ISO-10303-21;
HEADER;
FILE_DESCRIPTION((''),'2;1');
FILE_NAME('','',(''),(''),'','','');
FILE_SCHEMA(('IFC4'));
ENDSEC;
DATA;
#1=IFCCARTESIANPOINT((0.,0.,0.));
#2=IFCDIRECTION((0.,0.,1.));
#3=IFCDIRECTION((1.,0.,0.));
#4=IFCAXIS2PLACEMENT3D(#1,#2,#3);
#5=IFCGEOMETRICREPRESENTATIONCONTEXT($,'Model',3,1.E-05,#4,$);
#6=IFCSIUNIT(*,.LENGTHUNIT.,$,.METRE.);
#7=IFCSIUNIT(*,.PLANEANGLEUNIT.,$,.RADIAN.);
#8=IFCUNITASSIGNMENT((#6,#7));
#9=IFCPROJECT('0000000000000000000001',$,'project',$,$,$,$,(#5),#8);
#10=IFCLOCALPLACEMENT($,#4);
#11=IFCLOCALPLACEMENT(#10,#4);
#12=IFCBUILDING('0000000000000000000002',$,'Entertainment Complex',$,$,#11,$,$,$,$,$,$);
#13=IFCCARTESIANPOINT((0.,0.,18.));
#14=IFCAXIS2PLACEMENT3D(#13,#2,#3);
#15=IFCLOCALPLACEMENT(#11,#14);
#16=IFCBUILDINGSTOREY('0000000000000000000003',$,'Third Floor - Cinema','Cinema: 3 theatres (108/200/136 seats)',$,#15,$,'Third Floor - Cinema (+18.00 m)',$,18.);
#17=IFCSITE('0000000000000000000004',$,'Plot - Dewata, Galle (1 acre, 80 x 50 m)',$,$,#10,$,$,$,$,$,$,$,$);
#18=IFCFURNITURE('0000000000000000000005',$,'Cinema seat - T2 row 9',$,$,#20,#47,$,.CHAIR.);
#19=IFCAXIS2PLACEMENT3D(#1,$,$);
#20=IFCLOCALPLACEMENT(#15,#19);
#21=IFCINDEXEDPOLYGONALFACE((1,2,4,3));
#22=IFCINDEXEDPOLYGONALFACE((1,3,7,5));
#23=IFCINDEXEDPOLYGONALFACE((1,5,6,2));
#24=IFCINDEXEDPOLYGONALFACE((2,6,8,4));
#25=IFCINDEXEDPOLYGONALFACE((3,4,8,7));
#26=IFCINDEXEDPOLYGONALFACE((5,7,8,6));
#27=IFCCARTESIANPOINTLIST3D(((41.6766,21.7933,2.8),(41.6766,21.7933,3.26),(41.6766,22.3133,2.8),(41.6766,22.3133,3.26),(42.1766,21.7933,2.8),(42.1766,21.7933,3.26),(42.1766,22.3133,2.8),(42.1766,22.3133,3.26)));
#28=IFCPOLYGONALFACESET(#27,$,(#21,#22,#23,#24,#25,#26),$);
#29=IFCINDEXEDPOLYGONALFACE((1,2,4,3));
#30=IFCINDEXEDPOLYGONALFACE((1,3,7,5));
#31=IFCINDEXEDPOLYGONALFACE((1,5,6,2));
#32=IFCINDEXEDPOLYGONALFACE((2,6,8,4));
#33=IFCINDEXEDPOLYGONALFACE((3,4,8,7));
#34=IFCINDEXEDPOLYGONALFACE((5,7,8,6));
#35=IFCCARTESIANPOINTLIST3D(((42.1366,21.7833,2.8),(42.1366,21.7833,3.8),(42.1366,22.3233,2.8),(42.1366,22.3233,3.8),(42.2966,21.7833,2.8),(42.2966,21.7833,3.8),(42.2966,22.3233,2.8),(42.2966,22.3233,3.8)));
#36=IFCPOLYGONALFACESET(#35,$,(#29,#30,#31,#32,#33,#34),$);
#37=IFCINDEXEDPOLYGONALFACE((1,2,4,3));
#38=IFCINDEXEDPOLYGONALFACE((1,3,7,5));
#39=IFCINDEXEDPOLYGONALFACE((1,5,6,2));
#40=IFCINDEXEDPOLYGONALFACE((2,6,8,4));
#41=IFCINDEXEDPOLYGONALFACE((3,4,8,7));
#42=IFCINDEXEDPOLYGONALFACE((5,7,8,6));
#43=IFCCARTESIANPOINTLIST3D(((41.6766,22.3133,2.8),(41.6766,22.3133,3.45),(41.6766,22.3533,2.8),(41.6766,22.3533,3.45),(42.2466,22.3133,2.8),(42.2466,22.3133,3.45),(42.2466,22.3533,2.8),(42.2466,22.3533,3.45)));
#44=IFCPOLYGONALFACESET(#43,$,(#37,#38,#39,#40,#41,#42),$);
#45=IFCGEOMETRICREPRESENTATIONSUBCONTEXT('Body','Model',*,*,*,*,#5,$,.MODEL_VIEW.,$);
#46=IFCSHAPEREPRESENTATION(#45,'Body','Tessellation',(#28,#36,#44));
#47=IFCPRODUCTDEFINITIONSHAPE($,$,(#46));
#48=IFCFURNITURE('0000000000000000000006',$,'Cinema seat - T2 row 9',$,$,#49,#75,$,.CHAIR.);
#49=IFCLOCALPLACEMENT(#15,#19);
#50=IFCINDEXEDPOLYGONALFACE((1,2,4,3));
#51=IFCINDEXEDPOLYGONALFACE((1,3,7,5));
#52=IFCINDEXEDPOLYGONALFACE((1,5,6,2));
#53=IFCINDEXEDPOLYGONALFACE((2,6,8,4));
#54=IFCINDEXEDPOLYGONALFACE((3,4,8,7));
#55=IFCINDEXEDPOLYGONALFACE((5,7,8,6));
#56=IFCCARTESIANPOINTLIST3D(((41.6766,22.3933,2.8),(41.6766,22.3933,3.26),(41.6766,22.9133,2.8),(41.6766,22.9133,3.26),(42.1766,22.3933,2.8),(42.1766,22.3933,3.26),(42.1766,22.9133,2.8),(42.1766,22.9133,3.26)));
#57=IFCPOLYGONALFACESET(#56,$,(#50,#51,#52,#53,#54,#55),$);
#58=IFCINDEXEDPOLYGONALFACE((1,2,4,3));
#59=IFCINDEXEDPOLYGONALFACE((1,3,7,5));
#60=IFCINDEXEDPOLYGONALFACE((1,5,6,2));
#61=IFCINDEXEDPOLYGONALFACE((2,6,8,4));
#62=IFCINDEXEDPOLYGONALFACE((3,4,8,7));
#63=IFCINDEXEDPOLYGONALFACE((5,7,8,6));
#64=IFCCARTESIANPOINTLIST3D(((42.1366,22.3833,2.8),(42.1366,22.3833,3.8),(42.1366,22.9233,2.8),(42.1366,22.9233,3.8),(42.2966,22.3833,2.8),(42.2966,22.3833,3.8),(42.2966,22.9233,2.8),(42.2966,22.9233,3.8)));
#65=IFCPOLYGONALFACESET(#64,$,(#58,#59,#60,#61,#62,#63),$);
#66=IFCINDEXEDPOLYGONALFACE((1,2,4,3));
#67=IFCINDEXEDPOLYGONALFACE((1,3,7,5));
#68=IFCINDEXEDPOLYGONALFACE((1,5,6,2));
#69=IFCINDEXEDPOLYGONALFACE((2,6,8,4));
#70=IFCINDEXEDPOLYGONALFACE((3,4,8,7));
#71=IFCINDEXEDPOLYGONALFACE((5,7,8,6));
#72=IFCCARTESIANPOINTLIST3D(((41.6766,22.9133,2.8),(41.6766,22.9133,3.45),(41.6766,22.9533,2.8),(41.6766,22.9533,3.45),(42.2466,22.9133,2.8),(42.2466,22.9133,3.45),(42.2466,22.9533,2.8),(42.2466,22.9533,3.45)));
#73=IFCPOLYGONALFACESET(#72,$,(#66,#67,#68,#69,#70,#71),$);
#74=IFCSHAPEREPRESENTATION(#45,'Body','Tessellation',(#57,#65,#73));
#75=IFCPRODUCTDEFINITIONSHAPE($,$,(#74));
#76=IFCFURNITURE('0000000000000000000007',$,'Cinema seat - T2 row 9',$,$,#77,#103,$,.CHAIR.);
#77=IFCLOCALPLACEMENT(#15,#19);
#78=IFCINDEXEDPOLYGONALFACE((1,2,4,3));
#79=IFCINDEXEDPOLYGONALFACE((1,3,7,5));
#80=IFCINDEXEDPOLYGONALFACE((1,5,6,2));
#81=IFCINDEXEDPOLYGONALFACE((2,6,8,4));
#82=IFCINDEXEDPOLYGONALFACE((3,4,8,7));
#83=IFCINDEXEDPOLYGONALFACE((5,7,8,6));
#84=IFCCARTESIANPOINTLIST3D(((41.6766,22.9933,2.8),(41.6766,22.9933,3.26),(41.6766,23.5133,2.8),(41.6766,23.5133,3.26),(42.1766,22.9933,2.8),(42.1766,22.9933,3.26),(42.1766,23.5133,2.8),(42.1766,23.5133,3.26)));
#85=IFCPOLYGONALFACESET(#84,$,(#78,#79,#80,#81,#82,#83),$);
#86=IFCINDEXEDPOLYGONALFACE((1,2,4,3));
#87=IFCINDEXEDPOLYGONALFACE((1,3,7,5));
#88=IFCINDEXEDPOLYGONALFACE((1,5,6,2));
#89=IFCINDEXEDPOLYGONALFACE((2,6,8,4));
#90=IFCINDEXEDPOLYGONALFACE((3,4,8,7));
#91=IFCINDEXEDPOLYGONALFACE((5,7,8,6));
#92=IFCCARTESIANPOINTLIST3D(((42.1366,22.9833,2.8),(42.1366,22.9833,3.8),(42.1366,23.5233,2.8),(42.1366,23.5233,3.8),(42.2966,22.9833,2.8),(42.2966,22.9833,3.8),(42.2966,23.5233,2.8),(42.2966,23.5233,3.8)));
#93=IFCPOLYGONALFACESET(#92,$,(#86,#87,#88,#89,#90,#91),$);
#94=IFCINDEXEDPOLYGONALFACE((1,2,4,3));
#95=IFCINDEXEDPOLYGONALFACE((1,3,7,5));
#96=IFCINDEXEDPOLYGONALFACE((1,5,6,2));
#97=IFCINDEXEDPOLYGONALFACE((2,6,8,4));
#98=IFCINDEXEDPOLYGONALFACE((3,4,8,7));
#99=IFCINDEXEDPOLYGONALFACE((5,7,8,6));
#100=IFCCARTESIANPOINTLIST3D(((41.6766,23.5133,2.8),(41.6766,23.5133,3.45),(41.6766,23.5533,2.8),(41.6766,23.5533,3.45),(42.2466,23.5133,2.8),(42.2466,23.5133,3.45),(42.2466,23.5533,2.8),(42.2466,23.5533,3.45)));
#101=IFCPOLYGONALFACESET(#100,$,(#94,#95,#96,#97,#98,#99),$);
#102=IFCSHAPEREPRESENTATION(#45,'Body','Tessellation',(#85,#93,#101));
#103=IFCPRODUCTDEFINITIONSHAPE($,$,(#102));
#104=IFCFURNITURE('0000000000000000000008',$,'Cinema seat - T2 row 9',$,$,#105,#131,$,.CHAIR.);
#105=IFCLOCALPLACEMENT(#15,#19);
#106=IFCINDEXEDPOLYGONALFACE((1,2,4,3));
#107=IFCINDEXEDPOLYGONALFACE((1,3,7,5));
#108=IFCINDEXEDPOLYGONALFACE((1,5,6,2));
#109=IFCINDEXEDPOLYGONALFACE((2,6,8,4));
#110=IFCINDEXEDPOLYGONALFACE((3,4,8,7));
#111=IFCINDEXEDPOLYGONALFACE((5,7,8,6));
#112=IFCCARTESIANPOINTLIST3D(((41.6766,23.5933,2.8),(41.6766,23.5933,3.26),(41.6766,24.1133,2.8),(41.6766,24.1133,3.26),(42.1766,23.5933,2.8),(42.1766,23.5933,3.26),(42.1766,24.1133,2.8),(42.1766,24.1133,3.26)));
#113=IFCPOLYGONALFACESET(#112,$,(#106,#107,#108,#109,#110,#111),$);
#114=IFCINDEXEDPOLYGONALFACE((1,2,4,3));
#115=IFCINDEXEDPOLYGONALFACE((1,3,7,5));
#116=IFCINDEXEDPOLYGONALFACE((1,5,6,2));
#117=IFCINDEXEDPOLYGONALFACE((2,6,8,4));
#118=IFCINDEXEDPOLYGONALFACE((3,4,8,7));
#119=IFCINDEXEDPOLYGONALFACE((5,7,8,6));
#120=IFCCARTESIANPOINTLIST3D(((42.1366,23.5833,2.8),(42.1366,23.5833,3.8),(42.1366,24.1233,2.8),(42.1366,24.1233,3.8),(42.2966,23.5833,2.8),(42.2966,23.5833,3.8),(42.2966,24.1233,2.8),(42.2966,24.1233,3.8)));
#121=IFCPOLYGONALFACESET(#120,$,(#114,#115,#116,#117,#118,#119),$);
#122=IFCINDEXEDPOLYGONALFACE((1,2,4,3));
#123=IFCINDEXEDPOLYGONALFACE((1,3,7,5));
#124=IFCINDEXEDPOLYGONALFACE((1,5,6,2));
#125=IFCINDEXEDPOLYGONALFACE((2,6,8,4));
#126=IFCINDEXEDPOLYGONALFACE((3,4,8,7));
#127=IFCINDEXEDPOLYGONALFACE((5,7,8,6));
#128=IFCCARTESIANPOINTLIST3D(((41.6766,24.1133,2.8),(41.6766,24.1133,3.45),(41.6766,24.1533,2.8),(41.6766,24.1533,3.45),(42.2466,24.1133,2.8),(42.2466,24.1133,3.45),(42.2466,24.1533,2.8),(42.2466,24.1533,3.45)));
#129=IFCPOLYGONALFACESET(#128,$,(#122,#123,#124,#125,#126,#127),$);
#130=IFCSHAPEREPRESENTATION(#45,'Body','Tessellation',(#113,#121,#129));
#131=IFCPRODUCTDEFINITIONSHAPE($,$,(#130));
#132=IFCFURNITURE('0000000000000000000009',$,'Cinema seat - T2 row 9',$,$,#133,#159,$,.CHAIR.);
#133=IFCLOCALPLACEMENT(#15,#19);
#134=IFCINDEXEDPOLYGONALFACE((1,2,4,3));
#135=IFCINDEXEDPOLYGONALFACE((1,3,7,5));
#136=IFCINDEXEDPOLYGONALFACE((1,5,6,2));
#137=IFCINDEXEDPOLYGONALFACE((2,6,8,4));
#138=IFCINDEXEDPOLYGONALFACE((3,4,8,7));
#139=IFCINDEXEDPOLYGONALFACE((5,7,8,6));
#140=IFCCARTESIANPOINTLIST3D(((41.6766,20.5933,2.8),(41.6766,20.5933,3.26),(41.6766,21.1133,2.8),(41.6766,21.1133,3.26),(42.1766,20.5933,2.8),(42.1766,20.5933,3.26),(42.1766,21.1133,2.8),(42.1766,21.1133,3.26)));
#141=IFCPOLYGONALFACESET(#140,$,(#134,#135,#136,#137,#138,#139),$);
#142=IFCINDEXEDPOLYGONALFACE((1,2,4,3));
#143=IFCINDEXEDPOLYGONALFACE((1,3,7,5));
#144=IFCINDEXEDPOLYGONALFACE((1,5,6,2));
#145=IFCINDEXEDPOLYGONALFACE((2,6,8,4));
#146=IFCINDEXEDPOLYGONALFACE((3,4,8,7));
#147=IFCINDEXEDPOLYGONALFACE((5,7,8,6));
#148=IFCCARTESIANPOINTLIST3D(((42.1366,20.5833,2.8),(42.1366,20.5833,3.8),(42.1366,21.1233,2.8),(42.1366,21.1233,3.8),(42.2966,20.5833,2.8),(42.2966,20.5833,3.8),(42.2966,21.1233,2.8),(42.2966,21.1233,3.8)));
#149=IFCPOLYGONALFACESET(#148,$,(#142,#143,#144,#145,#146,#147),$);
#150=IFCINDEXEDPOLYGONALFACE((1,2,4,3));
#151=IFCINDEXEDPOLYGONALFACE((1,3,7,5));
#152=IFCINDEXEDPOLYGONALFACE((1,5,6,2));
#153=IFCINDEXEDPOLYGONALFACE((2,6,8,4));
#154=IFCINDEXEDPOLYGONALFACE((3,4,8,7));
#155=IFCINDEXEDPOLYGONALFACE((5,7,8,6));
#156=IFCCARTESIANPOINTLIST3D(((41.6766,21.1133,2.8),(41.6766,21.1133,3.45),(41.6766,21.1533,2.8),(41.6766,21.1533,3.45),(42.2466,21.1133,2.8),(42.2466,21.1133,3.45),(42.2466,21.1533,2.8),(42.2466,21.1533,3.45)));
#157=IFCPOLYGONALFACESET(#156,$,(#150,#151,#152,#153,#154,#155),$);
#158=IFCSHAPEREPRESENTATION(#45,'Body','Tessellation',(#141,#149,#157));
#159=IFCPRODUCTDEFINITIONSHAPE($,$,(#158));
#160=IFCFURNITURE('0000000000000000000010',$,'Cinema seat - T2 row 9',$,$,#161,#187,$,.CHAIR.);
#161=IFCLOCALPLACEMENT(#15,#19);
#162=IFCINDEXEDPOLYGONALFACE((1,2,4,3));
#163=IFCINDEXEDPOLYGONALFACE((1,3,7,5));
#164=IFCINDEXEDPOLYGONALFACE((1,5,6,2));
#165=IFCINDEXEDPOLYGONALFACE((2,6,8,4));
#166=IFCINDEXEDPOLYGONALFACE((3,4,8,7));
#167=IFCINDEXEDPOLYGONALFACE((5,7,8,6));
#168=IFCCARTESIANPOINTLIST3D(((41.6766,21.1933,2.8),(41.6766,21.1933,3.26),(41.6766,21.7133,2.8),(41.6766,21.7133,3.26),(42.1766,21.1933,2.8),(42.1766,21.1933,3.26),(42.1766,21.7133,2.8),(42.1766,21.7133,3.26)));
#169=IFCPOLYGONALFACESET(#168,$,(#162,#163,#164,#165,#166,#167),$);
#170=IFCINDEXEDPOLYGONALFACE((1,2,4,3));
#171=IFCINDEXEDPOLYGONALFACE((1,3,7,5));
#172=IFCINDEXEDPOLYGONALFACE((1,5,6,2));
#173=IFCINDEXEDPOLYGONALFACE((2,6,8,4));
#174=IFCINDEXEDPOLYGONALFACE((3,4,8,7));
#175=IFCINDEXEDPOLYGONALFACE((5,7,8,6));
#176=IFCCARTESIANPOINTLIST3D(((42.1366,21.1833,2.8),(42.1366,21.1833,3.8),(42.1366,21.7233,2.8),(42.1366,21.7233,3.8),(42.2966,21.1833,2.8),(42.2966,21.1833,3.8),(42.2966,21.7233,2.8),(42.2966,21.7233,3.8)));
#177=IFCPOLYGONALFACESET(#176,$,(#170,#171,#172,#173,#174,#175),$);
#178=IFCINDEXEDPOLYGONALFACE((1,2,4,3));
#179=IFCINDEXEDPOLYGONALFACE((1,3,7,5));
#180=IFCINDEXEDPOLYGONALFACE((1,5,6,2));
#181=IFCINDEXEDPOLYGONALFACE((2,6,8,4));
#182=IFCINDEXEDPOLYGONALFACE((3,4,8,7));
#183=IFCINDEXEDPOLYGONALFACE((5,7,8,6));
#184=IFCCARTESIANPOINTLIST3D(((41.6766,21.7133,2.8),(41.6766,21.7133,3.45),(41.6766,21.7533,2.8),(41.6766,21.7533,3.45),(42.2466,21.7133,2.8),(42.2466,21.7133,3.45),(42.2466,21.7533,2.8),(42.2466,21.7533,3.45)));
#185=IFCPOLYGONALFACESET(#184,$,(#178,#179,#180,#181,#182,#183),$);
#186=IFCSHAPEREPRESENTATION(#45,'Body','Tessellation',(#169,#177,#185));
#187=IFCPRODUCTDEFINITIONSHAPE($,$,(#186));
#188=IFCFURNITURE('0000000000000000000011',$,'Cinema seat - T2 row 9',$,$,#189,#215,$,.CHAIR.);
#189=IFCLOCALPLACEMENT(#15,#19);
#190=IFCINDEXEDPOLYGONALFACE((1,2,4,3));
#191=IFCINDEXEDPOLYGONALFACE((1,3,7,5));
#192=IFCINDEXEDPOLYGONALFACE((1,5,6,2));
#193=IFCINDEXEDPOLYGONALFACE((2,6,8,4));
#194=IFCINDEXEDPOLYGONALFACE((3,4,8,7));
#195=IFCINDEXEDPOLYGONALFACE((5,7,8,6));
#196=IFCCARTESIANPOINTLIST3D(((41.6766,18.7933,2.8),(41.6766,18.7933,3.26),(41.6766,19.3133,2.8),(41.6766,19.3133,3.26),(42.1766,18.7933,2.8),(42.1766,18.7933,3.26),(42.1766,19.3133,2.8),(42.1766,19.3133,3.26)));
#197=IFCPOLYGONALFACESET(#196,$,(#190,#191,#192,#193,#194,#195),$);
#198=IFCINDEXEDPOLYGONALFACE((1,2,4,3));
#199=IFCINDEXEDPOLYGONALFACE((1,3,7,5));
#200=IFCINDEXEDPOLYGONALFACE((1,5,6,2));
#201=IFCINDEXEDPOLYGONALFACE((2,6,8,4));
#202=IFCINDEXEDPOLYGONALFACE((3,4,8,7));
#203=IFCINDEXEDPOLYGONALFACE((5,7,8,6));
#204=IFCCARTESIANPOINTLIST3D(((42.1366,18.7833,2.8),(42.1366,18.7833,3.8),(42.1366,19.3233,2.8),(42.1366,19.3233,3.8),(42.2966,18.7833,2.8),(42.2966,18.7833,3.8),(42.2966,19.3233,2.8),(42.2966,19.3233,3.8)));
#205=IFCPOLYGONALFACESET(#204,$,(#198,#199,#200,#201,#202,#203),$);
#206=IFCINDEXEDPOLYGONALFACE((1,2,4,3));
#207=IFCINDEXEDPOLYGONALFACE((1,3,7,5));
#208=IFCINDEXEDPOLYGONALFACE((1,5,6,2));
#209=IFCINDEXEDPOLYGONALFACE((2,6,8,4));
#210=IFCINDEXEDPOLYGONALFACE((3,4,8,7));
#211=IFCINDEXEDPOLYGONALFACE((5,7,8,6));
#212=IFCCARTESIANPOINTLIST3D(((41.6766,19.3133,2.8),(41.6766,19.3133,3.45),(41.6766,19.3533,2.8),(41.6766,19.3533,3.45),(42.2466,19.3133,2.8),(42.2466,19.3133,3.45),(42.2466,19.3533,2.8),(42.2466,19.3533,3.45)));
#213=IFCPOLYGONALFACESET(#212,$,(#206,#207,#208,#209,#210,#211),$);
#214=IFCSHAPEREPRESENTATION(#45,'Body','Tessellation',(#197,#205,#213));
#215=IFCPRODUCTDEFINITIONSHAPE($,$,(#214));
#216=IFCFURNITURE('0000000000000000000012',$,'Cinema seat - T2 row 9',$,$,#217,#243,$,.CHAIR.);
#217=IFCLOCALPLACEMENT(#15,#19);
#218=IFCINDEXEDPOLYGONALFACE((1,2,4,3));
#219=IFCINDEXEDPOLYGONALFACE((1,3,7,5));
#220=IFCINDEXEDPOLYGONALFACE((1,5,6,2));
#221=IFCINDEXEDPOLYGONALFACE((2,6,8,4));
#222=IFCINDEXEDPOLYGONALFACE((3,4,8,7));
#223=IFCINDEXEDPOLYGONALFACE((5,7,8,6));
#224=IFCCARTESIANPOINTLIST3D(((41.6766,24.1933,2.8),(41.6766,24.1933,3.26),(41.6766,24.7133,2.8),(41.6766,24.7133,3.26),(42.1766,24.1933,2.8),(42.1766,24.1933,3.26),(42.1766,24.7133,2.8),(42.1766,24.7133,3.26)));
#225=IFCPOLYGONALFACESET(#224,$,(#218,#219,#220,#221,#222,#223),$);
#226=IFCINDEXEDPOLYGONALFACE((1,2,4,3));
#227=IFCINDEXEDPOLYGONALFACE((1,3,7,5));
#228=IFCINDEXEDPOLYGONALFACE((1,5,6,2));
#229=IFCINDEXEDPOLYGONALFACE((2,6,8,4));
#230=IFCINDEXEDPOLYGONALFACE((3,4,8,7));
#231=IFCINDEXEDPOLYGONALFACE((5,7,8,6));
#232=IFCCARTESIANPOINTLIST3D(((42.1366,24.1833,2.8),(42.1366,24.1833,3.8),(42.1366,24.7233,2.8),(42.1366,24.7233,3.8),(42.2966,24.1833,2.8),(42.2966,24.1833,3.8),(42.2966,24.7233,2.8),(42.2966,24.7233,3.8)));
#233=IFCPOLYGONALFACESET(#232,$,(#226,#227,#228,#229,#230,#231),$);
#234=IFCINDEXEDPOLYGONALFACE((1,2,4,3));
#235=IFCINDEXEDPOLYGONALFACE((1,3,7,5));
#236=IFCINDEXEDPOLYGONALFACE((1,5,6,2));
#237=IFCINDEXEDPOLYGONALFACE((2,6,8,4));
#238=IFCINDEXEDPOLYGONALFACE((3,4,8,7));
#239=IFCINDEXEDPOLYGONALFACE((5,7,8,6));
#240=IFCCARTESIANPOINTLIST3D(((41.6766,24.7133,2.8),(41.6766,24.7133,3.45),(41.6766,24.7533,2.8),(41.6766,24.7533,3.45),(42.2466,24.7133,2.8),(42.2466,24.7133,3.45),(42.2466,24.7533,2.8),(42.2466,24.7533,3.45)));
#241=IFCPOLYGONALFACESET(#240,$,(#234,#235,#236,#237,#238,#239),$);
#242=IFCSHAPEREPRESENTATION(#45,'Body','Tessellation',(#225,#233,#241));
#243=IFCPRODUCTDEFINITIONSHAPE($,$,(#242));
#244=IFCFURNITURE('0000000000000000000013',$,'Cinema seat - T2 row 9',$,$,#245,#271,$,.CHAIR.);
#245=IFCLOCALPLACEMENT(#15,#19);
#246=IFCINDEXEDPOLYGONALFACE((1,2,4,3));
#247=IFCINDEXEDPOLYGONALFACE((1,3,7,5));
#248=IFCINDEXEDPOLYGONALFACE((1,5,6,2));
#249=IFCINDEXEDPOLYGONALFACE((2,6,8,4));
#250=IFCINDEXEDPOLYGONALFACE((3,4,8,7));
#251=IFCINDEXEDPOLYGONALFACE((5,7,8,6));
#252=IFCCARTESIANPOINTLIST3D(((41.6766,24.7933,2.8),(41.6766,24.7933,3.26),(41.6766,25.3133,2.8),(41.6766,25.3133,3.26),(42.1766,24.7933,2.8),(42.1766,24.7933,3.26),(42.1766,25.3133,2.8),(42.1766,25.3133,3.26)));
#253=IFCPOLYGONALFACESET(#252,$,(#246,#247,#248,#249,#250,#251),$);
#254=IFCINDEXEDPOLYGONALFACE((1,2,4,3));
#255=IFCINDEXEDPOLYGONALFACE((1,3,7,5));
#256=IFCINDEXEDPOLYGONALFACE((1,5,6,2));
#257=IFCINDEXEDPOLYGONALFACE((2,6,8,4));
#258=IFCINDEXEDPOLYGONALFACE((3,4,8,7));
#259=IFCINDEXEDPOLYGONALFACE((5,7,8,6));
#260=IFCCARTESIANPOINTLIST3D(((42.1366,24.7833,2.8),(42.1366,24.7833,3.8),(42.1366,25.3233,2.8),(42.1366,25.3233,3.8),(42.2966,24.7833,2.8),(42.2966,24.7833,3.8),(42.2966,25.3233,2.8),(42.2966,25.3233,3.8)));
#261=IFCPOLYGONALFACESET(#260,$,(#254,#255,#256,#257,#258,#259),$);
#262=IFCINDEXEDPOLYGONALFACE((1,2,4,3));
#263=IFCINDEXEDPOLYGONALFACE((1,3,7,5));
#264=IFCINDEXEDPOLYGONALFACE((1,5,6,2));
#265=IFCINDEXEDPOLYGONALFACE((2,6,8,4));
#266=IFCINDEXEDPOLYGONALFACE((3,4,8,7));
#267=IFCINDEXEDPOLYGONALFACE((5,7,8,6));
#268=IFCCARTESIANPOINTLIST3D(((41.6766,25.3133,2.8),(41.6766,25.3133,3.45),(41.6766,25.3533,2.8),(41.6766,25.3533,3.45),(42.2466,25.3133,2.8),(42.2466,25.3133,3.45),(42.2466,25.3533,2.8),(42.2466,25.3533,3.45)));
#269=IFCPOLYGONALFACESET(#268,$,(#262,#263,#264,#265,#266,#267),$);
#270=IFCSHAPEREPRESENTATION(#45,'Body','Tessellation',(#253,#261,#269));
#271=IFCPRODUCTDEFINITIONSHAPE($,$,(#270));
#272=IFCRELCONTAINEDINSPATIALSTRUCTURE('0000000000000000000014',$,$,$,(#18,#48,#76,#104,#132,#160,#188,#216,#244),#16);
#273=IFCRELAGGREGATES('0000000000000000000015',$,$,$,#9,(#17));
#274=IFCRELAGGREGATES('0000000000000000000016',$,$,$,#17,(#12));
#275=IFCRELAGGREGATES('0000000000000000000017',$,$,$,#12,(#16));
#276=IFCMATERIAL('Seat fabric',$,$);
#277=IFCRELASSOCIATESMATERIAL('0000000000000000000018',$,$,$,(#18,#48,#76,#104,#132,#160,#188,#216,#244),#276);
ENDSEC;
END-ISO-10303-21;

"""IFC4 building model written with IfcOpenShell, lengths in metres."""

from ifc_helpers import new_model, si_unit, frame, origin_with_axes, place, context, subcontext, project, spatial, polyline, outline, extrude, material, element, save


model = new_model("IFC4")

# Units and contexts
model_context = context("Model", 3, precision=1e-05, world=origin_with_axes())
body_context = subcontext(model_context, "Body", "Model", "MODEL_VIEW")
ifc_project = project(units=[si_unit("LENGTHUNIT", "METRE"), si_unit("PLANEANGLEUNIT", "RADIAN")], contexts=[model_context])

# Site, building, storey
site_placement = place(None, origin_with_axes())
site = spatial("IfcSite", under=ifc_project, at=site_placement, Name="Plot - Dewata, Galle (1 acre, 80 x 50 m)")
building_placement = place(site_placement, origin_with_axes())
building = spatial("IfcBuilding", under=site, at=building_placement, Name="Entertainment Complex")
storey_placement = place(building_placement, frame((0.0, 0.0, 18.0), z_axis=(0.0, 0.0, 1.0), x_axis=(1.0, 0.0, 0.0)))
storey = spatial("IfcBuildingStorey", under=building, at=storey_placement, Name="Third Floor - Cinema", Description="Cinema: 3 theatres (108/200/136 seats)", LongName="Third Floor - Cinema (+18.00 m)", Elevation=18.0)

# Furniture
ifc_material_1 = material(Name="Seat fabric")
for number, where, z_axis, x_axis, name in (
    (1, (42.2966, 22.0533, 2.8), (0.0, 0.0, 1.0), (1.0, 0.0, 0.0), "Cinema seat - T2 row 9"),
    (2, (42.2966, 22.6533, 2.8), (0.0, 0.0, 1.0), (1.0, 0.0, 0.0), "Cinema seat - T2 row 9"),
    (3, (42.2966, 23.2533, 2.8), (0.0, 0.0, 1.0), (1.0, 0.0, 0.0), "Cinema seat - T2 row 9"),
    (4, (42.2966, 23.8533, 2.8), (0.0, 0.0, 1.0), (1.0, 0.0, 0.0), "Cinema seat - T2 row 9"),
    (5, (42.2966, 20.8533, 2.8), (0.0, 0.0, 1.0), (1.0, 0.0, 0.0), "Cinema seat - T2 row 9"),
    (6, (42.2966, 21.4533, 2.8), (0.0, 0.0, 1.0), (1.0, 0.0, 0.0), "Cinema seat - T2 row 9"),
    (7, (42.2966, 19.0533, 2.8), (0.0, 0.0, 1.0), (1.0, 0.0, 0.0), "Cinema seat - T2 row 9"),
    (8, (42.2966, 24.4533, 2.8), (0.0, 0.0, 1.0), (1.0, 0.0, 0.0), "Cinema seat - T2 row 9"),
    (9, (42.2966, 25.0533, 2.8), (0.0, 0.0, 1.0), (1.0, 0.0, 0.0), "Cinema seat - T2 row 9"),
):
    element("IfcFurniture", number, at=place(storey_placement, frame(where, z_axis=z_axis, x_axis=x_axis)), inside=storey, material=ifc_material_1, Name=name, PredefinedType="CHAIR", context=body_context, shape_type="SweptSolid", body=[
        extrude(outline(polyline([(-0.62, -0.26), (-0.12, -0.26), (-0.12, 0.26), (-0.62, 0.26), (-0.62, -0.26)])), origin_with_axes(), (0.0, 0.0, 1.0), 0.46),
        extrude(outline(polyline([(-0.16, -0.27), (0.0, -0.27), (0.0, 0.27), (-0.16, 0.27), (-0.16, -0.27)])), origin_with_axes(), (0.0, 0.0, 1.0), 1.0),
        extrude(outline(polyline([(-0.62, 0.26), (-0.05, 0.26), (-0.05, 0.3), (-0.62, 0.3), (-0.62, 0.26)])), origin_with_axes(), (0.0, 0.0, 1.0), 0.65),
    ])

save(model, "model.ifc")
